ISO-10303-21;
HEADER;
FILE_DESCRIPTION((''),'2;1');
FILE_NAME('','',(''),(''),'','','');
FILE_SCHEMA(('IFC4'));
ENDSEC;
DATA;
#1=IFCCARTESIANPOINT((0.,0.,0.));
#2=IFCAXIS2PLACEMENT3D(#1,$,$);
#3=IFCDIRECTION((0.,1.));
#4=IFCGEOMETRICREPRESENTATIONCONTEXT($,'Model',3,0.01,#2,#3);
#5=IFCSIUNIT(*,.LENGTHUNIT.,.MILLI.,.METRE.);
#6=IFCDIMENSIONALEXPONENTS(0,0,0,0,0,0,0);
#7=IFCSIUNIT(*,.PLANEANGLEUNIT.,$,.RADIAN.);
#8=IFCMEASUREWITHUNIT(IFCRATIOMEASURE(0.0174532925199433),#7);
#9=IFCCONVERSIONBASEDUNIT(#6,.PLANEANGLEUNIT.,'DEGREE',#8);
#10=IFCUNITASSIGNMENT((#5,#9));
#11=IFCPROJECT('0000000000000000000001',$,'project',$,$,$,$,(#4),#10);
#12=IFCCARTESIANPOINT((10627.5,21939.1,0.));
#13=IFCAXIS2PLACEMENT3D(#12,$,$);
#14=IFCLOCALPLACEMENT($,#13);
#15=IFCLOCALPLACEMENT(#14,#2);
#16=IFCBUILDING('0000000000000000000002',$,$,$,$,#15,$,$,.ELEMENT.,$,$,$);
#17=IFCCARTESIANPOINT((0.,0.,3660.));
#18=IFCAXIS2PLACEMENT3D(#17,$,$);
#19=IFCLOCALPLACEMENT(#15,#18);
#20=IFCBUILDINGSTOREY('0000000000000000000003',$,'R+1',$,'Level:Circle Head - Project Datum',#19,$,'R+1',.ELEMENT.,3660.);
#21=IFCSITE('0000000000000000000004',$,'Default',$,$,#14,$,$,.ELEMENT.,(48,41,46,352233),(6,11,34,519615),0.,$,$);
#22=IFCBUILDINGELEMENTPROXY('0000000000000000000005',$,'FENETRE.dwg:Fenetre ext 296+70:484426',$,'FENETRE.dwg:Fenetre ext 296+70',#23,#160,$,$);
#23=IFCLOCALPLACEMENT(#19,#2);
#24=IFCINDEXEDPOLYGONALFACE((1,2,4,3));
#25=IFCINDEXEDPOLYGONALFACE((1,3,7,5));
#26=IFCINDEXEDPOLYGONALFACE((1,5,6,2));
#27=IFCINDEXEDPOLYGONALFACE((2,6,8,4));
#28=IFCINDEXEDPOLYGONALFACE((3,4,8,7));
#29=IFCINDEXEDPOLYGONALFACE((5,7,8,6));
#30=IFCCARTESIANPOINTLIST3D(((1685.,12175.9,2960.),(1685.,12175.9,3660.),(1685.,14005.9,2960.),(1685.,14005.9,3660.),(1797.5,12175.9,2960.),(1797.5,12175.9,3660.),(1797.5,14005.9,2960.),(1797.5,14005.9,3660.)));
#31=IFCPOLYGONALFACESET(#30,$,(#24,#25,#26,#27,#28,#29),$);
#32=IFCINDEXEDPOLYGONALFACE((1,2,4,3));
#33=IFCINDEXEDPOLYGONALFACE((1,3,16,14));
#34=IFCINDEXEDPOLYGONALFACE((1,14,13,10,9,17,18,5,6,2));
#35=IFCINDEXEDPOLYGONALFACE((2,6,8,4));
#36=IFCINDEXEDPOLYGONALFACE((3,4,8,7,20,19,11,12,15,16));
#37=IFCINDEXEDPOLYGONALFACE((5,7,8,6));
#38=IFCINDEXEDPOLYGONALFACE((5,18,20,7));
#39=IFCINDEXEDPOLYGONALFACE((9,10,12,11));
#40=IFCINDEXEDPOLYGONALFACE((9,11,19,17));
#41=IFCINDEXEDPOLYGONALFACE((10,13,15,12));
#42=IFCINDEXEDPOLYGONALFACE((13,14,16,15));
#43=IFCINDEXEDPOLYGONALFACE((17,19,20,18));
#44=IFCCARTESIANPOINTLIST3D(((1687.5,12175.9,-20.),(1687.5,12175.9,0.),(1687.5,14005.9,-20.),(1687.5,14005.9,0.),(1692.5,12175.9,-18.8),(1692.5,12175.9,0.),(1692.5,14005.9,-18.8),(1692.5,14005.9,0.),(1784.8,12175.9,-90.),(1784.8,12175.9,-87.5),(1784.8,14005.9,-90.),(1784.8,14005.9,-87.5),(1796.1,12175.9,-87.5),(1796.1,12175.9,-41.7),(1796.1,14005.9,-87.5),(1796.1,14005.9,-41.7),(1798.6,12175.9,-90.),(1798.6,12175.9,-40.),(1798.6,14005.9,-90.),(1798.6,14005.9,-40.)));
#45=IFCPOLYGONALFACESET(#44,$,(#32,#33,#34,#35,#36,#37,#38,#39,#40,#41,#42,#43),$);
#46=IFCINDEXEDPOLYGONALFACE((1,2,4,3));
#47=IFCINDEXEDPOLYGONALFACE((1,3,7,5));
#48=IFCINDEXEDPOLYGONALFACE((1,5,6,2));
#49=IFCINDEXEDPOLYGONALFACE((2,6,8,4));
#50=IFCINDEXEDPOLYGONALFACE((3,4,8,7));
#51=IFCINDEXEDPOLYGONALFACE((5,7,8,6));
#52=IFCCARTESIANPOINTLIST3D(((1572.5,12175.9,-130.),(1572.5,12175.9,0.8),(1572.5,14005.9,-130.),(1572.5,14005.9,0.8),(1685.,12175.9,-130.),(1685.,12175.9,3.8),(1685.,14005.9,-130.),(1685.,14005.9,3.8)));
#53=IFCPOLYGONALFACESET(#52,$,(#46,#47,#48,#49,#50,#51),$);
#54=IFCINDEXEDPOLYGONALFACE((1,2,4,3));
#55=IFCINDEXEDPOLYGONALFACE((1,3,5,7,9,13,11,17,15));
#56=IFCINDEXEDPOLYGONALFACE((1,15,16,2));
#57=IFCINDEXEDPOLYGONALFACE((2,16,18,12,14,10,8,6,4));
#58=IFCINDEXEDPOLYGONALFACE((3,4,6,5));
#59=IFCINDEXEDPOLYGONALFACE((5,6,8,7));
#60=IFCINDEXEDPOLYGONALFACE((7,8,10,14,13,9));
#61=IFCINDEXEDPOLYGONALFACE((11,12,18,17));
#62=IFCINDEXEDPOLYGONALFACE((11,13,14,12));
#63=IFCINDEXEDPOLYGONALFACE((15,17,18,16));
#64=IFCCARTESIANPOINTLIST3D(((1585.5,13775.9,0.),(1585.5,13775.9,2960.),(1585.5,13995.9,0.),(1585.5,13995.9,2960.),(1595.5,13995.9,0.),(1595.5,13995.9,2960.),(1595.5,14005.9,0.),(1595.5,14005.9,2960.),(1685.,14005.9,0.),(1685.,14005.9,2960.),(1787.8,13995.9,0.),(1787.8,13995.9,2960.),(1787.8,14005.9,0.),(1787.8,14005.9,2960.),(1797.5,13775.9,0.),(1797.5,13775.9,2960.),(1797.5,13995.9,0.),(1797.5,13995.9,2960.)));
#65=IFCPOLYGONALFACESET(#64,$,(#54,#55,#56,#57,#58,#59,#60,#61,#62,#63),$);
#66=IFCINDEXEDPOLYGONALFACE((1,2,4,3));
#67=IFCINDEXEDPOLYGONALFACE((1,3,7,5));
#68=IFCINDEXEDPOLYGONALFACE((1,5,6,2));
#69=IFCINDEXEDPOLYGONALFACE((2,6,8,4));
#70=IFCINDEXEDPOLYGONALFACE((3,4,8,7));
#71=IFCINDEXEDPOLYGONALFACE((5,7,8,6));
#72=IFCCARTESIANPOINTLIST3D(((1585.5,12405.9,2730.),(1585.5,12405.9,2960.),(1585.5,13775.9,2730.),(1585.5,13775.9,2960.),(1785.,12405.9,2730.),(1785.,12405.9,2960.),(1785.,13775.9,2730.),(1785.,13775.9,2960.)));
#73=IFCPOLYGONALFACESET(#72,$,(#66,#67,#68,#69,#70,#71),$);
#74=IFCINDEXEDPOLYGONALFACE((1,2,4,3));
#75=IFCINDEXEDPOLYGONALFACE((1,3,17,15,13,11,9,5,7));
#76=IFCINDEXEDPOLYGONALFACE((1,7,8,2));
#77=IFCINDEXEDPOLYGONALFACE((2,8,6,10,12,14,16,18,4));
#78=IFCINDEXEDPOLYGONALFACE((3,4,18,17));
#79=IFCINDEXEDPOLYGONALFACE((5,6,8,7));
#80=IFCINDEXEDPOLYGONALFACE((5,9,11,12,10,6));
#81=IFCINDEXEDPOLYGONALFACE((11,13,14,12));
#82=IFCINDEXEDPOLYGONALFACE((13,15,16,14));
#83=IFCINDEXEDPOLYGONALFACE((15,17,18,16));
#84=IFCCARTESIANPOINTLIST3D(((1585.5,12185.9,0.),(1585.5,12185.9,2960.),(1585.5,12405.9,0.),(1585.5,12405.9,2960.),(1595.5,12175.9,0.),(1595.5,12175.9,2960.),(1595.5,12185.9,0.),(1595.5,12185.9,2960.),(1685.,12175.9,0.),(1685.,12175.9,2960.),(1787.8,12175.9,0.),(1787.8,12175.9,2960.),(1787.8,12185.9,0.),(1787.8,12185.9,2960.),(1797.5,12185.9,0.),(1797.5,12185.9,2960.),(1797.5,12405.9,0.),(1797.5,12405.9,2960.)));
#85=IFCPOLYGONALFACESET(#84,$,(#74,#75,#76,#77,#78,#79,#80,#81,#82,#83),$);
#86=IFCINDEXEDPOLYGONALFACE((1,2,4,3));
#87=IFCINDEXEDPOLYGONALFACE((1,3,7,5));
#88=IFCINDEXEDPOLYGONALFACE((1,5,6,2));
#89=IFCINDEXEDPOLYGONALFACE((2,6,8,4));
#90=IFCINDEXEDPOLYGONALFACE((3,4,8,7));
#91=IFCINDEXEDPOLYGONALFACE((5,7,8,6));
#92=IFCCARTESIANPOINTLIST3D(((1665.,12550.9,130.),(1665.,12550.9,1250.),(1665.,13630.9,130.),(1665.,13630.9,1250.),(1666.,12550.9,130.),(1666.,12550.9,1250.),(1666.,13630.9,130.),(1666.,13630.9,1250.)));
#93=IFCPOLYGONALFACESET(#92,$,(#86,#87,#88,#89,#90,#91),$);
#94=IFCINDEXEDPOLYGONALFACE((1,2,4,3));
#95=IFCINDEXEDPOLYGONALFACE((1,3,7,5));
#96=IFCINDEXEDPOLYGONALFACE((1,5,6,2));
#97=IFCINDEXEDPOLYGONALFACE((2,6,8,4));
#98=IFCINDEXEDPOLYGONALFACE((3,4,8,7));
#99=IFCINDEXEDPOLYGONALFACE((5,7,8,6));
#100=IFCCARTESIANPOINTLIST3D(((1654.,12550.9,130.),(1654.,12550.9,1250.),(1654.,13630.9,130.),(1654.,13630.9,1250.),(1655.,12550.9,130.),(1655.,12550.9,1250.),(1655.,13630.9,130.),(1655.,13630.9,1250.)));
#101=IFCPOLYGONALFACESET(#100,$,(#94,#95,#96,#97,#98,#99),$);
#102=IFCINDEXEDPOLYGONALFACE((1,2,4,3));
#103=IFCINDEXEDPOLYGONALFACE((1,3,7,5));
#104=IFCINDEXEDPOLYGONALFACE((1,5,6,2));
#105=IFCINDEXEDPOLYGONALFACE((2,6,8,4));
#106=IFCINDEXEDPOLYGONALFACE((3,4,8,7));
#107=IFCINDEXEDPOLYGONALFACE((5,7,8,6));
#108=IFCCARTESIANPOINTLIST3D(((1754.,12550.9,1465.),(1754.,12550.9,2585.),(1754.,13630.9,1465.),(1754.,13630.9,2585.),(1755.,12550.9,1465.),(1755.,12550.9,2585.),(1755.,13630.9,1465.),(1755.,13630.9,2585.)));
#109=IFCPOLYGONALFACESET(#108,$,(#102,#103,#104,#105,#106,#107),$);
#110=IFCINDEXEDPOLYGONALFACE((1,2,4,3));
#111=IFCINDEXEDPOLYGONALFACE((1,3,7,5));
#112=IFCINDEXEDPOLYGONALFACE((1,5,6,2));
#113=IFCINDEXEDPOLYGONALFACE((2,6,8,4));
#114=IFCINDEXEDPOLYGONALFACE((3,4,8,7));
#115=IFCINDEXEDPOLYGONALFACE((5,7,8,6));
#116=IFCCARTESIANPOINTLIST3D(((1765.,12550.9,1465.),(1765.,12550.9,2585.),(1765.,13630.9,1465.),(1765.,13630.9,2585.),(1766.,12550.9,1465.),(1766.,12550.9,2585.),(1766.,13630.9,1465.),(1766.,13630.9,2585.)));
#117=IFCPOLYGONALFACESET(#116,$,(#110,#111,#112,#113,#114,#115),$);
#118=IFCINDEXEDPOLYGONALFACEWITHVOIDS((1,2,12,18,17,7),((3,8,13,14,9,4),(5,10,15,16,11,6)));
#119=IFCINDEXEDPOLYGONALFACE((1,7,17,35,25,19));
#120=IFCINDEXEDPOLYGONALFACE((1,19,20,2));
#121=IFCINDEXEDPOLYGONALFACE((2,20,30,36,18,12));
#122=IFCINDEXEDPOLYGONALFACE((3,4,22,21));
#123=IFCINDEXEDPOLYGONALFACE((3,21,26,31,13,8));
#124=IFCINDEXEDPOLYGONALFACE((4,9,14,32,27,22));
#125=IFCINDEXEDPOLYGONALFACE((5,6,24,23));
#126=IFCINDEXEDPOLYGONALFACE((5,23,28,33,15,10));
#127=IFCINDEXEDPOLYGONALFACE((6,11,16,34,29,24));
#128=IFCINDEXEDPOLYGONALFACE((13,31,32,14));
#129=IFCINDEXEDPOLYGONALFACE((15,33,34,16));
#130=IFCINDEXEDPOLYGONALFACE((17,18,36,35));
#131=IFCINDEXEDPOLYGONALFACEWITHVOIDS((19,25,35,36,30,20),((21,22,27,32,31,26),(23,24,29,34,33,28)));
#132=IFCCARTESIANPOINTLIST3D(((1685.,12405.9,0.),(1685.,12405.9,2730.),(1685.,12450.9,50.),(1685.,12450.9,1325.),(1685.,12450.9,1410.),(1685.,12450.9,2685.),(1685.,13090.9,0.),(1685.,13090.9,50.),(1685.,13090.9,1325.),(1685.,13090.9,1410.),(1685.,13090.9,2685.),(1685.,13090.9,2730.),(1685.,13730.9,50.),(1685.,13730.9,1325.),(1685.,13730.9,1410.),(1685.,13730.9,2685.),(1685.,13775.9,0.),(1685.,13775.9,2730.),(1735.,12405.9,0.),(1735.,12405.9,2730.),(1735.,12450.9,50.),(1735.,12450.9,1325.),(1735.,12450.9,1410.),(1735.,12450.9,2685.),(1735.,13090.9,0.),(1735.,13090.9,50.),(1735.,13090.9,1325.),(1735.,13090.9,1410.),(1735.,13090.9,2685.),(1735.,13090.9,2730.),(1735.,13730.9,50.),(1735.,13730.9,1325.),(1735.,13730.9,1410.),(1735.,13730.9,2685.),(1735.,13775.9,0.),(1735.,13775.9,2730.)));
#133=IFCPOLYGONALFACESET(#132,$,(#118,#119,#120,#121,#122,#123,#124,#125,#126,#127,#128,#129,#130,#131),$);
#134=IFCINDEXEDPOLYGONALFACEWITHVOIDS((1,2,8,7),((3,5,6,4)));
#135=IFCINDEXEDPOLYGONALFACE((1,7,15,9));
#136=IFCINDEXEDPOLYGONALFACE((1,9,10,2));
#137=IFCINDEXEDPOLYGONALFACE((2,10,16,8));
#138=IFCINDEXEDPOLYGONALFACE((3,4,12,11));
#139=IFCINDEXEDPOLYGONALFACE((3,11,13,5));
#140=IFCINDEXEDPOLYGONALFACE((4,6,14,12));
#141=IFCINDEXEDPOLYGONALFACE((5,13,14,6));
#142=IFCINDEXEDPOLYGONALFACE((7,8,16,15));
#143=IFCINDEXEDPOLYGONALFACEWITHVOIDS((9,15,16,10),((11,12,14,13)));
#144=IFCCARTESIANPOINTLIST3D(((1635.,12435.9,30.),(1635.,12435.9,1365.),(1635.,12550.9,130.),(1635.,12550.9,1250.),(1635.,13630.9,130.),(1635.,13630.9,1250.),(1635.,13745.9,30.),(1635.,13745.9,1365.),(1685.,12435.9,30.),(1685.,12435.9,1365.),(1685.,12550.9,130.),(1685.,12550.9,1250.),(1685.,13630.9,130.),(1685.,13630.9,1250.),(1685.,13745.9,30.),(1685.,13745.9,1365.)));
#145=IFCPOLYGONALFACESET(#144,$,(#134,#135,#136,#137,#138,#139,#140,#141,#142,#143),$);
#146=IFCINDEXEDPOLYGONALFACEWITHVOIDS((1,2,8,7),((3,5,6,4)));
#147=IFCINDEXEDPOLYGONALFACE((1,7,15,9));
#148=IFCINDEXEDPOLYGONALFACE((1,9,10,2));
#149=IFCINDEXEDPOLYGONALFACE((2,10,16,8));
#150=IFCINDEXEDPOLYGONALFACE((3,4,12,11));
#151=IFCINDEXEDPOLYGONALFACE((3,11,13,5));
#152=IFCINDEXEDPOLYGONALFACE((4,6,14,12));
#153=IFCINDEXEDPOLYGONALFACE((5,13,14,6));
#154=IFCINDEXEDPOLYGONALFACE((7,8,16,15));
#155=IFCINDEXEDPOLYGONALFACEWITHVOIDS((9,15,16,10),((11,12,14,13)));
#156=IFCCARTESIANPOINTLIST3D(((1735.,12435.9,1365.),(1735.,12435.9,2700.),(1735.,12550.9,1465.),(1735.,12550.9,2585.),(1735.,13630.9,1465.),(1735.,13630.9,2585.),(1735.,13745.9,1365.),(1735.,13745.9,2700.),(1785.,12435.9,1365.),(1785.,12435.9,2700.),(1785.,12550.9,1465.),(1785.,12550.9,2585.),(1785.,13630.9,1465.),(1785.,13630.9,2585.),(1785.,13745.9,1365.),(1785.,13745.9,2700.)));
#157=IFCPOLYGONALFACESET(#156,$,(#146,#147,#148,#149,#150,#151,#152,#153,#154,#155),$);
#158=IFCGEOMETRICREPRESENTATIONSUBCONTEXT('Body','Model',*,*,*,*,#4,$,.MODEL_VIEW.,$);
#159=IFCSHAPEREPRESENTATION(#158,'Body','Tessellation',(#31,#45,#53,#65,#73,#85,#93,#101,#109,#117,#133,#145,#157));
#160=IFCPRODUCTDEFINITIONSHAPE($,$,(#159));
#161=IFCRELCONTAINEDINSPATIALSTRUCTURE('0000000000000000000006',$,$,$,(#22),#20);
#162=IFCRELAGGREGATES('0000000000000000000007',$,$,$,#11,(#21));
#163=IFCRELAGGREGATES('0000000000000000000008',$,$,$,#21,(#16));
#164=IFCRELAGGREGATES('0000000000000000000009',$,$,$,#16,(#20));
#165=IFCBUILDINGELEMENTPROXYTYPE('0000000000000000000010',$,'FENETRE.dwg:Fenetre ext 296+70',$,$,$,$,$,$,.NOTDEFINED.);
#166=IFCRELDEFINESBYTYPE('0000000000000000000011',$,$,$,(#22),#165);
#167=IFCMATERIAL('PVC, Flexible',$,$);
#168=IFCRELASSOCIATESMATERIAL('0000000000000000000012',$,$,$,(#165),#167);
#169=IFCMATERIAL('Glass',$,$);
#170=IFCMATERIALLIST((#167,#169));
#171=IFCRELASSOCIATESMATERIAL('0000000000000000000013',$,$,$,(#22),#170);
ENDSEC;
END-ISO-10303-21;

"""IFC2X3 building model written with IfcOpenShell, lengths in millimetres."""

from ifc_helpers import new_model, entity, si_unit, converted_unit, direction, frame, frame_2d, origin, origin_2d_with_axis, place, context, subcontext, project, spatial, polyline, rectangle, outline, extrude, source, transform, mapped, material, material_list, type_object, type_shapes, element, save


model = new_model("IFC2X3")

# Units and contexts
model_context = context("Model", 3, precision=0.01, world=origin(), true_north=direction((0.0, 1.0)))
body_context = subcontext(model_context, "Body", "Model", "MODEL_VIEW")
ifc_project = project(units=[si_unit("LENGTHUNIT", "METRE", prefix="MILLI"), converted_unit("PLANEANGLEUNIT", "DEGREE", entity("IfcRatioMeasure", 0.0174532925199433), si_unit("PLANEANGLEUNIT", "RADIAN"), dimensions=[0, 0, 0, 0, 0, 0, 0])], contexts=[model_context])

# Site, building, storey
site_placement = place(None, frame((10627.5, 21939.1, 0.0)))
site = spatial("IfcSite", under=ifc_project, at=site_placement, Name="Default", CompositionType="ELEMENT", RefLatitude=(48, 41, 46, 352233), RefLongitude=(6, 11, 34, 519615), RefElevation=0.0)
building_placement = place(site_placement, origin())
building = spatial("IfcBuilding", under=site, at=building_placement, CompositionType="ELEMENT")
storey_placement = place(building_placement, frame((0.0, 0.0, 3660.0)))
storey = spatial("IfcBuildingStorey", under=building, at=storey_placement, Name="R+1", ObjectType="Level:Circle Head - Project Datum", LongName="R+1", CompositionType="ELEMENT", Elevation=3660.0)

# Building element proxy
ifc_material_1 = material(Name="PVC, Flexible")
ifc_material_2 = material(Name="Glass")
building_element_proxy_type_1 = type_object("IfcBuildingElementProxyType", Name="FENETRE.dwg:Fenetre ext 296+70", PredefinedType="NOTDEFINED", material=ifc_material_1)
shared_shape_1 = source(origin(), body_context, "Body", "SweptSolid", [
    extrude(rectangle(XDim=112.5, YDim=1830.0, at=origin_2d_with_axis()), frame((-10.4, -56.3, 2960.0), z_axis=(0.0, 0.0, 1.0), x_axis=(0.0, 1.0, 0.0)), (0.0, 0.0, 1.0), 700.0),
    extrude(outline(polyline([(27.5, -64.4), (47.5, -64.4), (47.5, -59.4), (28.8, -59.4), (7.5, 46.7), (-42.5, 46.7), (-42.5, 32.9), (-40.0, 32.9), (-40.0, 44.2), (5.8, 44.2), (27.5, -64.4)])), frame((-925.4, -66.9, -47.5), z_axis=(1.0, 0.0, 0.0), x_axis=(0.0, 0.0, 1.0)), (0.0, 0.0, 1.0), 1830.0),
    extrude(outline(polyline([(-54.5, -66.1), (58.0, -66.1), (54.5, 67.6), (-58.0, 64.6), (-54.5, -66.1)])), frame((-925.4, 56.3, -63.8), z_axis=(1.0, 0.0, 0.0), x_axis=(0.0, -0.999645, 0.02665)), (0.0, 0.0, 1.0), 1830.0),
    extrude(outline(polyline([(-97.0, -55.6), (5.9, -55.6), (95.4, -55.6), (95.4, -45.6), (105.4, -45.6), (105.4, 174.4), (-106.6, 174.4), (-106.6, -45.6), (-97.0, -45.6), (-97.0, -55.6)])), frame((849.0, -5.9, 0.0), z_axis=(0.0, 0.0, 1.0), x_axis=(0.0, 1.0, 0.0)), (0.0, 0.0, 1.0), 2960.0),
    extrude(rectangle(XDim=1370.0, YDim=199.5, at=origin_2d_with_axis()), frame((-10.4, -0.3, 2730.0), z_axis=(0.0, 0.0, 1.0), x_axis=(-1.0, 0.0, 0.0)), (0.0, 0.0, 1.0), 230.0),
    extrude(outline(polyline([(-55.6, 97.0), (-55.6, -5.9), (-55.6, -95.4), (-45.6, -95.4), (-45.6, -105.4), (174.4, -105.4), (174.4, 106.6), (-45.6, 106.6), (-45.6, 97.0), (-55.6, 97.0)])), frame((-869.9, -5.9, 0.0), z_axis=(0.0, 0.0, -1.0), x_axis=(1.0, 0.0, 0.0)), (0.0, 0.0, -1.0), 2960.0),
    extrude(rectangle(XDim=1080.0, YDim=1.0, at=origin_2d_with_axis()), frame((-10.4, 19.5, 130.0), z_axis=(0.0, 0.0, 1.0), x_axis=(-1.0, 0.0, 0.0)), (0.0, 0.0, 1.0), 1120.0),
    extrude(rectangle(XDim=1080.0, YDim=1.0, at=origin_2d_with_axis()), frame((-10.4, 30.5, 130.0), z_axis=(0.0, 0.0, 1.0), x_axis=(-1.0, 0.0, 0.0)), (0.0, 0.0, 1.0), 1120.0),
    extrude(rectangle(XDim=1080.0, YDim=1.0, at=frame_2d((0.0, 0.0), x_axis=(1.0, 0.0))), frame((-10.4, -69.5, 1465.0), z_axis=(0.0, 0.0, 1.0), x_axis=(-1.0, 0.0, 0.0)), (0.0, 0.0, 1.0), 1120.0),
    extrude(rectangle(XDim=1080.0, YDim=1.0, at=frame_2d((0.0, 0.0), x_axis=(1.0, 0.0))), frame((-10.4, -80.5, 1465.0), z_axis=(0.0, 0.0, 1.0), x_axis=(-1.0, 0.0, 0.0)), (0.0, 0.0, 1.0), 1120.0),
    extrude(outline(polyline([(-685.0, -1365.0), (0.0, -1365.0), (685.0, -1365.0), (685.0, 1365.0), (0.0, 1365.0), (-685.0, 1365.0), (-685.0, -1365.0)]), holes=[polyline([(-640.0, -1320.0), (-640.0, -45.0), (0.0, -45.0), (640.0, -45.0), (640.0, -1320.0), (0.0, -1320.0), (-640.0, -1320.0)]), polyline([(-640.0, 40.0), (-640.0, 1315.0), (0.0, 1315.0), (640.0, 1315.0), (640.0, 40.0), (0.0, 40.0), (-640.0, 40.0)])]), frame((-10.4, -50.0, 1365.0), z_axis=(0.0, 1.0, 0.0), x_axis=(1.0, 0.0, 0.0)), (0.0, 0.0, 1.0), 50.0),
    extrude(outline(polyline([(-655.0, -667.5), (655.0, -667.5), (655.0, 667.5), (-655.0, 667.5), (-655.0, -667.5)]), holes=[polyline([(-540.0, 552.5), (540.0, 552.5), (540.0, -567.5), (-540.0, -567.5), (-540.0, 552.5)])]), frame((-10.4, 0.0, 697.5), z_axis=(0.0, 1.0, 0.0), x_axis=(-1.0, 0.0, 0.0)), (0.0, 0.0, 1.0), 50.0),
    extrude(outline(polyline([(-655.0, -667.5), (655.0, -667.5), (655.0, 667.5), (-655.0, 667.5), (-655.0, -667.5)]), holes=[polyline([(-540.0, 552.5), (540.0, 552.5), (540.0, -567.5), (-540.0, -567.5), (-540.0, 552.5)])]), frame((-10.4, -100.0, 2032.5), z_axis=(0.0, 1.0, 0.0), x_axis=(-1.0, 0.0, 0.0)), (0.0, 0.0, 1.0), 50.0),
])
type_shapes(building_element_proxy_type_1, [shared_shape_1])
ifc_material_list_1 = material_list([ifc_material_1, ifc_material_2])
proxy_1_placement = place(storey_placement, frame((1685.0, 13101.3, 0.0), z_axis=(0.0, 0.0, 1.0), x_axis=(0.0, 1.0, 0.0)))
element("IfcBuildingElementProxy", 1, at=proxy_1_placement, inside=storey, type_object=building_element_proxy_type_1, material=ifc_material_list_1, Name="FENETRE.dwg:Fenetre ext 296+70:484426", ObjectType="FENETRE.dwg:Fenetre ext 296+70", context=body_context, shape_type="MappedRepresentation", body=[
    mapped(shared_shape_1, transform((0.0, 0.0, 0.0), scale=1.0)),
])

save(model, "model.ifc")
